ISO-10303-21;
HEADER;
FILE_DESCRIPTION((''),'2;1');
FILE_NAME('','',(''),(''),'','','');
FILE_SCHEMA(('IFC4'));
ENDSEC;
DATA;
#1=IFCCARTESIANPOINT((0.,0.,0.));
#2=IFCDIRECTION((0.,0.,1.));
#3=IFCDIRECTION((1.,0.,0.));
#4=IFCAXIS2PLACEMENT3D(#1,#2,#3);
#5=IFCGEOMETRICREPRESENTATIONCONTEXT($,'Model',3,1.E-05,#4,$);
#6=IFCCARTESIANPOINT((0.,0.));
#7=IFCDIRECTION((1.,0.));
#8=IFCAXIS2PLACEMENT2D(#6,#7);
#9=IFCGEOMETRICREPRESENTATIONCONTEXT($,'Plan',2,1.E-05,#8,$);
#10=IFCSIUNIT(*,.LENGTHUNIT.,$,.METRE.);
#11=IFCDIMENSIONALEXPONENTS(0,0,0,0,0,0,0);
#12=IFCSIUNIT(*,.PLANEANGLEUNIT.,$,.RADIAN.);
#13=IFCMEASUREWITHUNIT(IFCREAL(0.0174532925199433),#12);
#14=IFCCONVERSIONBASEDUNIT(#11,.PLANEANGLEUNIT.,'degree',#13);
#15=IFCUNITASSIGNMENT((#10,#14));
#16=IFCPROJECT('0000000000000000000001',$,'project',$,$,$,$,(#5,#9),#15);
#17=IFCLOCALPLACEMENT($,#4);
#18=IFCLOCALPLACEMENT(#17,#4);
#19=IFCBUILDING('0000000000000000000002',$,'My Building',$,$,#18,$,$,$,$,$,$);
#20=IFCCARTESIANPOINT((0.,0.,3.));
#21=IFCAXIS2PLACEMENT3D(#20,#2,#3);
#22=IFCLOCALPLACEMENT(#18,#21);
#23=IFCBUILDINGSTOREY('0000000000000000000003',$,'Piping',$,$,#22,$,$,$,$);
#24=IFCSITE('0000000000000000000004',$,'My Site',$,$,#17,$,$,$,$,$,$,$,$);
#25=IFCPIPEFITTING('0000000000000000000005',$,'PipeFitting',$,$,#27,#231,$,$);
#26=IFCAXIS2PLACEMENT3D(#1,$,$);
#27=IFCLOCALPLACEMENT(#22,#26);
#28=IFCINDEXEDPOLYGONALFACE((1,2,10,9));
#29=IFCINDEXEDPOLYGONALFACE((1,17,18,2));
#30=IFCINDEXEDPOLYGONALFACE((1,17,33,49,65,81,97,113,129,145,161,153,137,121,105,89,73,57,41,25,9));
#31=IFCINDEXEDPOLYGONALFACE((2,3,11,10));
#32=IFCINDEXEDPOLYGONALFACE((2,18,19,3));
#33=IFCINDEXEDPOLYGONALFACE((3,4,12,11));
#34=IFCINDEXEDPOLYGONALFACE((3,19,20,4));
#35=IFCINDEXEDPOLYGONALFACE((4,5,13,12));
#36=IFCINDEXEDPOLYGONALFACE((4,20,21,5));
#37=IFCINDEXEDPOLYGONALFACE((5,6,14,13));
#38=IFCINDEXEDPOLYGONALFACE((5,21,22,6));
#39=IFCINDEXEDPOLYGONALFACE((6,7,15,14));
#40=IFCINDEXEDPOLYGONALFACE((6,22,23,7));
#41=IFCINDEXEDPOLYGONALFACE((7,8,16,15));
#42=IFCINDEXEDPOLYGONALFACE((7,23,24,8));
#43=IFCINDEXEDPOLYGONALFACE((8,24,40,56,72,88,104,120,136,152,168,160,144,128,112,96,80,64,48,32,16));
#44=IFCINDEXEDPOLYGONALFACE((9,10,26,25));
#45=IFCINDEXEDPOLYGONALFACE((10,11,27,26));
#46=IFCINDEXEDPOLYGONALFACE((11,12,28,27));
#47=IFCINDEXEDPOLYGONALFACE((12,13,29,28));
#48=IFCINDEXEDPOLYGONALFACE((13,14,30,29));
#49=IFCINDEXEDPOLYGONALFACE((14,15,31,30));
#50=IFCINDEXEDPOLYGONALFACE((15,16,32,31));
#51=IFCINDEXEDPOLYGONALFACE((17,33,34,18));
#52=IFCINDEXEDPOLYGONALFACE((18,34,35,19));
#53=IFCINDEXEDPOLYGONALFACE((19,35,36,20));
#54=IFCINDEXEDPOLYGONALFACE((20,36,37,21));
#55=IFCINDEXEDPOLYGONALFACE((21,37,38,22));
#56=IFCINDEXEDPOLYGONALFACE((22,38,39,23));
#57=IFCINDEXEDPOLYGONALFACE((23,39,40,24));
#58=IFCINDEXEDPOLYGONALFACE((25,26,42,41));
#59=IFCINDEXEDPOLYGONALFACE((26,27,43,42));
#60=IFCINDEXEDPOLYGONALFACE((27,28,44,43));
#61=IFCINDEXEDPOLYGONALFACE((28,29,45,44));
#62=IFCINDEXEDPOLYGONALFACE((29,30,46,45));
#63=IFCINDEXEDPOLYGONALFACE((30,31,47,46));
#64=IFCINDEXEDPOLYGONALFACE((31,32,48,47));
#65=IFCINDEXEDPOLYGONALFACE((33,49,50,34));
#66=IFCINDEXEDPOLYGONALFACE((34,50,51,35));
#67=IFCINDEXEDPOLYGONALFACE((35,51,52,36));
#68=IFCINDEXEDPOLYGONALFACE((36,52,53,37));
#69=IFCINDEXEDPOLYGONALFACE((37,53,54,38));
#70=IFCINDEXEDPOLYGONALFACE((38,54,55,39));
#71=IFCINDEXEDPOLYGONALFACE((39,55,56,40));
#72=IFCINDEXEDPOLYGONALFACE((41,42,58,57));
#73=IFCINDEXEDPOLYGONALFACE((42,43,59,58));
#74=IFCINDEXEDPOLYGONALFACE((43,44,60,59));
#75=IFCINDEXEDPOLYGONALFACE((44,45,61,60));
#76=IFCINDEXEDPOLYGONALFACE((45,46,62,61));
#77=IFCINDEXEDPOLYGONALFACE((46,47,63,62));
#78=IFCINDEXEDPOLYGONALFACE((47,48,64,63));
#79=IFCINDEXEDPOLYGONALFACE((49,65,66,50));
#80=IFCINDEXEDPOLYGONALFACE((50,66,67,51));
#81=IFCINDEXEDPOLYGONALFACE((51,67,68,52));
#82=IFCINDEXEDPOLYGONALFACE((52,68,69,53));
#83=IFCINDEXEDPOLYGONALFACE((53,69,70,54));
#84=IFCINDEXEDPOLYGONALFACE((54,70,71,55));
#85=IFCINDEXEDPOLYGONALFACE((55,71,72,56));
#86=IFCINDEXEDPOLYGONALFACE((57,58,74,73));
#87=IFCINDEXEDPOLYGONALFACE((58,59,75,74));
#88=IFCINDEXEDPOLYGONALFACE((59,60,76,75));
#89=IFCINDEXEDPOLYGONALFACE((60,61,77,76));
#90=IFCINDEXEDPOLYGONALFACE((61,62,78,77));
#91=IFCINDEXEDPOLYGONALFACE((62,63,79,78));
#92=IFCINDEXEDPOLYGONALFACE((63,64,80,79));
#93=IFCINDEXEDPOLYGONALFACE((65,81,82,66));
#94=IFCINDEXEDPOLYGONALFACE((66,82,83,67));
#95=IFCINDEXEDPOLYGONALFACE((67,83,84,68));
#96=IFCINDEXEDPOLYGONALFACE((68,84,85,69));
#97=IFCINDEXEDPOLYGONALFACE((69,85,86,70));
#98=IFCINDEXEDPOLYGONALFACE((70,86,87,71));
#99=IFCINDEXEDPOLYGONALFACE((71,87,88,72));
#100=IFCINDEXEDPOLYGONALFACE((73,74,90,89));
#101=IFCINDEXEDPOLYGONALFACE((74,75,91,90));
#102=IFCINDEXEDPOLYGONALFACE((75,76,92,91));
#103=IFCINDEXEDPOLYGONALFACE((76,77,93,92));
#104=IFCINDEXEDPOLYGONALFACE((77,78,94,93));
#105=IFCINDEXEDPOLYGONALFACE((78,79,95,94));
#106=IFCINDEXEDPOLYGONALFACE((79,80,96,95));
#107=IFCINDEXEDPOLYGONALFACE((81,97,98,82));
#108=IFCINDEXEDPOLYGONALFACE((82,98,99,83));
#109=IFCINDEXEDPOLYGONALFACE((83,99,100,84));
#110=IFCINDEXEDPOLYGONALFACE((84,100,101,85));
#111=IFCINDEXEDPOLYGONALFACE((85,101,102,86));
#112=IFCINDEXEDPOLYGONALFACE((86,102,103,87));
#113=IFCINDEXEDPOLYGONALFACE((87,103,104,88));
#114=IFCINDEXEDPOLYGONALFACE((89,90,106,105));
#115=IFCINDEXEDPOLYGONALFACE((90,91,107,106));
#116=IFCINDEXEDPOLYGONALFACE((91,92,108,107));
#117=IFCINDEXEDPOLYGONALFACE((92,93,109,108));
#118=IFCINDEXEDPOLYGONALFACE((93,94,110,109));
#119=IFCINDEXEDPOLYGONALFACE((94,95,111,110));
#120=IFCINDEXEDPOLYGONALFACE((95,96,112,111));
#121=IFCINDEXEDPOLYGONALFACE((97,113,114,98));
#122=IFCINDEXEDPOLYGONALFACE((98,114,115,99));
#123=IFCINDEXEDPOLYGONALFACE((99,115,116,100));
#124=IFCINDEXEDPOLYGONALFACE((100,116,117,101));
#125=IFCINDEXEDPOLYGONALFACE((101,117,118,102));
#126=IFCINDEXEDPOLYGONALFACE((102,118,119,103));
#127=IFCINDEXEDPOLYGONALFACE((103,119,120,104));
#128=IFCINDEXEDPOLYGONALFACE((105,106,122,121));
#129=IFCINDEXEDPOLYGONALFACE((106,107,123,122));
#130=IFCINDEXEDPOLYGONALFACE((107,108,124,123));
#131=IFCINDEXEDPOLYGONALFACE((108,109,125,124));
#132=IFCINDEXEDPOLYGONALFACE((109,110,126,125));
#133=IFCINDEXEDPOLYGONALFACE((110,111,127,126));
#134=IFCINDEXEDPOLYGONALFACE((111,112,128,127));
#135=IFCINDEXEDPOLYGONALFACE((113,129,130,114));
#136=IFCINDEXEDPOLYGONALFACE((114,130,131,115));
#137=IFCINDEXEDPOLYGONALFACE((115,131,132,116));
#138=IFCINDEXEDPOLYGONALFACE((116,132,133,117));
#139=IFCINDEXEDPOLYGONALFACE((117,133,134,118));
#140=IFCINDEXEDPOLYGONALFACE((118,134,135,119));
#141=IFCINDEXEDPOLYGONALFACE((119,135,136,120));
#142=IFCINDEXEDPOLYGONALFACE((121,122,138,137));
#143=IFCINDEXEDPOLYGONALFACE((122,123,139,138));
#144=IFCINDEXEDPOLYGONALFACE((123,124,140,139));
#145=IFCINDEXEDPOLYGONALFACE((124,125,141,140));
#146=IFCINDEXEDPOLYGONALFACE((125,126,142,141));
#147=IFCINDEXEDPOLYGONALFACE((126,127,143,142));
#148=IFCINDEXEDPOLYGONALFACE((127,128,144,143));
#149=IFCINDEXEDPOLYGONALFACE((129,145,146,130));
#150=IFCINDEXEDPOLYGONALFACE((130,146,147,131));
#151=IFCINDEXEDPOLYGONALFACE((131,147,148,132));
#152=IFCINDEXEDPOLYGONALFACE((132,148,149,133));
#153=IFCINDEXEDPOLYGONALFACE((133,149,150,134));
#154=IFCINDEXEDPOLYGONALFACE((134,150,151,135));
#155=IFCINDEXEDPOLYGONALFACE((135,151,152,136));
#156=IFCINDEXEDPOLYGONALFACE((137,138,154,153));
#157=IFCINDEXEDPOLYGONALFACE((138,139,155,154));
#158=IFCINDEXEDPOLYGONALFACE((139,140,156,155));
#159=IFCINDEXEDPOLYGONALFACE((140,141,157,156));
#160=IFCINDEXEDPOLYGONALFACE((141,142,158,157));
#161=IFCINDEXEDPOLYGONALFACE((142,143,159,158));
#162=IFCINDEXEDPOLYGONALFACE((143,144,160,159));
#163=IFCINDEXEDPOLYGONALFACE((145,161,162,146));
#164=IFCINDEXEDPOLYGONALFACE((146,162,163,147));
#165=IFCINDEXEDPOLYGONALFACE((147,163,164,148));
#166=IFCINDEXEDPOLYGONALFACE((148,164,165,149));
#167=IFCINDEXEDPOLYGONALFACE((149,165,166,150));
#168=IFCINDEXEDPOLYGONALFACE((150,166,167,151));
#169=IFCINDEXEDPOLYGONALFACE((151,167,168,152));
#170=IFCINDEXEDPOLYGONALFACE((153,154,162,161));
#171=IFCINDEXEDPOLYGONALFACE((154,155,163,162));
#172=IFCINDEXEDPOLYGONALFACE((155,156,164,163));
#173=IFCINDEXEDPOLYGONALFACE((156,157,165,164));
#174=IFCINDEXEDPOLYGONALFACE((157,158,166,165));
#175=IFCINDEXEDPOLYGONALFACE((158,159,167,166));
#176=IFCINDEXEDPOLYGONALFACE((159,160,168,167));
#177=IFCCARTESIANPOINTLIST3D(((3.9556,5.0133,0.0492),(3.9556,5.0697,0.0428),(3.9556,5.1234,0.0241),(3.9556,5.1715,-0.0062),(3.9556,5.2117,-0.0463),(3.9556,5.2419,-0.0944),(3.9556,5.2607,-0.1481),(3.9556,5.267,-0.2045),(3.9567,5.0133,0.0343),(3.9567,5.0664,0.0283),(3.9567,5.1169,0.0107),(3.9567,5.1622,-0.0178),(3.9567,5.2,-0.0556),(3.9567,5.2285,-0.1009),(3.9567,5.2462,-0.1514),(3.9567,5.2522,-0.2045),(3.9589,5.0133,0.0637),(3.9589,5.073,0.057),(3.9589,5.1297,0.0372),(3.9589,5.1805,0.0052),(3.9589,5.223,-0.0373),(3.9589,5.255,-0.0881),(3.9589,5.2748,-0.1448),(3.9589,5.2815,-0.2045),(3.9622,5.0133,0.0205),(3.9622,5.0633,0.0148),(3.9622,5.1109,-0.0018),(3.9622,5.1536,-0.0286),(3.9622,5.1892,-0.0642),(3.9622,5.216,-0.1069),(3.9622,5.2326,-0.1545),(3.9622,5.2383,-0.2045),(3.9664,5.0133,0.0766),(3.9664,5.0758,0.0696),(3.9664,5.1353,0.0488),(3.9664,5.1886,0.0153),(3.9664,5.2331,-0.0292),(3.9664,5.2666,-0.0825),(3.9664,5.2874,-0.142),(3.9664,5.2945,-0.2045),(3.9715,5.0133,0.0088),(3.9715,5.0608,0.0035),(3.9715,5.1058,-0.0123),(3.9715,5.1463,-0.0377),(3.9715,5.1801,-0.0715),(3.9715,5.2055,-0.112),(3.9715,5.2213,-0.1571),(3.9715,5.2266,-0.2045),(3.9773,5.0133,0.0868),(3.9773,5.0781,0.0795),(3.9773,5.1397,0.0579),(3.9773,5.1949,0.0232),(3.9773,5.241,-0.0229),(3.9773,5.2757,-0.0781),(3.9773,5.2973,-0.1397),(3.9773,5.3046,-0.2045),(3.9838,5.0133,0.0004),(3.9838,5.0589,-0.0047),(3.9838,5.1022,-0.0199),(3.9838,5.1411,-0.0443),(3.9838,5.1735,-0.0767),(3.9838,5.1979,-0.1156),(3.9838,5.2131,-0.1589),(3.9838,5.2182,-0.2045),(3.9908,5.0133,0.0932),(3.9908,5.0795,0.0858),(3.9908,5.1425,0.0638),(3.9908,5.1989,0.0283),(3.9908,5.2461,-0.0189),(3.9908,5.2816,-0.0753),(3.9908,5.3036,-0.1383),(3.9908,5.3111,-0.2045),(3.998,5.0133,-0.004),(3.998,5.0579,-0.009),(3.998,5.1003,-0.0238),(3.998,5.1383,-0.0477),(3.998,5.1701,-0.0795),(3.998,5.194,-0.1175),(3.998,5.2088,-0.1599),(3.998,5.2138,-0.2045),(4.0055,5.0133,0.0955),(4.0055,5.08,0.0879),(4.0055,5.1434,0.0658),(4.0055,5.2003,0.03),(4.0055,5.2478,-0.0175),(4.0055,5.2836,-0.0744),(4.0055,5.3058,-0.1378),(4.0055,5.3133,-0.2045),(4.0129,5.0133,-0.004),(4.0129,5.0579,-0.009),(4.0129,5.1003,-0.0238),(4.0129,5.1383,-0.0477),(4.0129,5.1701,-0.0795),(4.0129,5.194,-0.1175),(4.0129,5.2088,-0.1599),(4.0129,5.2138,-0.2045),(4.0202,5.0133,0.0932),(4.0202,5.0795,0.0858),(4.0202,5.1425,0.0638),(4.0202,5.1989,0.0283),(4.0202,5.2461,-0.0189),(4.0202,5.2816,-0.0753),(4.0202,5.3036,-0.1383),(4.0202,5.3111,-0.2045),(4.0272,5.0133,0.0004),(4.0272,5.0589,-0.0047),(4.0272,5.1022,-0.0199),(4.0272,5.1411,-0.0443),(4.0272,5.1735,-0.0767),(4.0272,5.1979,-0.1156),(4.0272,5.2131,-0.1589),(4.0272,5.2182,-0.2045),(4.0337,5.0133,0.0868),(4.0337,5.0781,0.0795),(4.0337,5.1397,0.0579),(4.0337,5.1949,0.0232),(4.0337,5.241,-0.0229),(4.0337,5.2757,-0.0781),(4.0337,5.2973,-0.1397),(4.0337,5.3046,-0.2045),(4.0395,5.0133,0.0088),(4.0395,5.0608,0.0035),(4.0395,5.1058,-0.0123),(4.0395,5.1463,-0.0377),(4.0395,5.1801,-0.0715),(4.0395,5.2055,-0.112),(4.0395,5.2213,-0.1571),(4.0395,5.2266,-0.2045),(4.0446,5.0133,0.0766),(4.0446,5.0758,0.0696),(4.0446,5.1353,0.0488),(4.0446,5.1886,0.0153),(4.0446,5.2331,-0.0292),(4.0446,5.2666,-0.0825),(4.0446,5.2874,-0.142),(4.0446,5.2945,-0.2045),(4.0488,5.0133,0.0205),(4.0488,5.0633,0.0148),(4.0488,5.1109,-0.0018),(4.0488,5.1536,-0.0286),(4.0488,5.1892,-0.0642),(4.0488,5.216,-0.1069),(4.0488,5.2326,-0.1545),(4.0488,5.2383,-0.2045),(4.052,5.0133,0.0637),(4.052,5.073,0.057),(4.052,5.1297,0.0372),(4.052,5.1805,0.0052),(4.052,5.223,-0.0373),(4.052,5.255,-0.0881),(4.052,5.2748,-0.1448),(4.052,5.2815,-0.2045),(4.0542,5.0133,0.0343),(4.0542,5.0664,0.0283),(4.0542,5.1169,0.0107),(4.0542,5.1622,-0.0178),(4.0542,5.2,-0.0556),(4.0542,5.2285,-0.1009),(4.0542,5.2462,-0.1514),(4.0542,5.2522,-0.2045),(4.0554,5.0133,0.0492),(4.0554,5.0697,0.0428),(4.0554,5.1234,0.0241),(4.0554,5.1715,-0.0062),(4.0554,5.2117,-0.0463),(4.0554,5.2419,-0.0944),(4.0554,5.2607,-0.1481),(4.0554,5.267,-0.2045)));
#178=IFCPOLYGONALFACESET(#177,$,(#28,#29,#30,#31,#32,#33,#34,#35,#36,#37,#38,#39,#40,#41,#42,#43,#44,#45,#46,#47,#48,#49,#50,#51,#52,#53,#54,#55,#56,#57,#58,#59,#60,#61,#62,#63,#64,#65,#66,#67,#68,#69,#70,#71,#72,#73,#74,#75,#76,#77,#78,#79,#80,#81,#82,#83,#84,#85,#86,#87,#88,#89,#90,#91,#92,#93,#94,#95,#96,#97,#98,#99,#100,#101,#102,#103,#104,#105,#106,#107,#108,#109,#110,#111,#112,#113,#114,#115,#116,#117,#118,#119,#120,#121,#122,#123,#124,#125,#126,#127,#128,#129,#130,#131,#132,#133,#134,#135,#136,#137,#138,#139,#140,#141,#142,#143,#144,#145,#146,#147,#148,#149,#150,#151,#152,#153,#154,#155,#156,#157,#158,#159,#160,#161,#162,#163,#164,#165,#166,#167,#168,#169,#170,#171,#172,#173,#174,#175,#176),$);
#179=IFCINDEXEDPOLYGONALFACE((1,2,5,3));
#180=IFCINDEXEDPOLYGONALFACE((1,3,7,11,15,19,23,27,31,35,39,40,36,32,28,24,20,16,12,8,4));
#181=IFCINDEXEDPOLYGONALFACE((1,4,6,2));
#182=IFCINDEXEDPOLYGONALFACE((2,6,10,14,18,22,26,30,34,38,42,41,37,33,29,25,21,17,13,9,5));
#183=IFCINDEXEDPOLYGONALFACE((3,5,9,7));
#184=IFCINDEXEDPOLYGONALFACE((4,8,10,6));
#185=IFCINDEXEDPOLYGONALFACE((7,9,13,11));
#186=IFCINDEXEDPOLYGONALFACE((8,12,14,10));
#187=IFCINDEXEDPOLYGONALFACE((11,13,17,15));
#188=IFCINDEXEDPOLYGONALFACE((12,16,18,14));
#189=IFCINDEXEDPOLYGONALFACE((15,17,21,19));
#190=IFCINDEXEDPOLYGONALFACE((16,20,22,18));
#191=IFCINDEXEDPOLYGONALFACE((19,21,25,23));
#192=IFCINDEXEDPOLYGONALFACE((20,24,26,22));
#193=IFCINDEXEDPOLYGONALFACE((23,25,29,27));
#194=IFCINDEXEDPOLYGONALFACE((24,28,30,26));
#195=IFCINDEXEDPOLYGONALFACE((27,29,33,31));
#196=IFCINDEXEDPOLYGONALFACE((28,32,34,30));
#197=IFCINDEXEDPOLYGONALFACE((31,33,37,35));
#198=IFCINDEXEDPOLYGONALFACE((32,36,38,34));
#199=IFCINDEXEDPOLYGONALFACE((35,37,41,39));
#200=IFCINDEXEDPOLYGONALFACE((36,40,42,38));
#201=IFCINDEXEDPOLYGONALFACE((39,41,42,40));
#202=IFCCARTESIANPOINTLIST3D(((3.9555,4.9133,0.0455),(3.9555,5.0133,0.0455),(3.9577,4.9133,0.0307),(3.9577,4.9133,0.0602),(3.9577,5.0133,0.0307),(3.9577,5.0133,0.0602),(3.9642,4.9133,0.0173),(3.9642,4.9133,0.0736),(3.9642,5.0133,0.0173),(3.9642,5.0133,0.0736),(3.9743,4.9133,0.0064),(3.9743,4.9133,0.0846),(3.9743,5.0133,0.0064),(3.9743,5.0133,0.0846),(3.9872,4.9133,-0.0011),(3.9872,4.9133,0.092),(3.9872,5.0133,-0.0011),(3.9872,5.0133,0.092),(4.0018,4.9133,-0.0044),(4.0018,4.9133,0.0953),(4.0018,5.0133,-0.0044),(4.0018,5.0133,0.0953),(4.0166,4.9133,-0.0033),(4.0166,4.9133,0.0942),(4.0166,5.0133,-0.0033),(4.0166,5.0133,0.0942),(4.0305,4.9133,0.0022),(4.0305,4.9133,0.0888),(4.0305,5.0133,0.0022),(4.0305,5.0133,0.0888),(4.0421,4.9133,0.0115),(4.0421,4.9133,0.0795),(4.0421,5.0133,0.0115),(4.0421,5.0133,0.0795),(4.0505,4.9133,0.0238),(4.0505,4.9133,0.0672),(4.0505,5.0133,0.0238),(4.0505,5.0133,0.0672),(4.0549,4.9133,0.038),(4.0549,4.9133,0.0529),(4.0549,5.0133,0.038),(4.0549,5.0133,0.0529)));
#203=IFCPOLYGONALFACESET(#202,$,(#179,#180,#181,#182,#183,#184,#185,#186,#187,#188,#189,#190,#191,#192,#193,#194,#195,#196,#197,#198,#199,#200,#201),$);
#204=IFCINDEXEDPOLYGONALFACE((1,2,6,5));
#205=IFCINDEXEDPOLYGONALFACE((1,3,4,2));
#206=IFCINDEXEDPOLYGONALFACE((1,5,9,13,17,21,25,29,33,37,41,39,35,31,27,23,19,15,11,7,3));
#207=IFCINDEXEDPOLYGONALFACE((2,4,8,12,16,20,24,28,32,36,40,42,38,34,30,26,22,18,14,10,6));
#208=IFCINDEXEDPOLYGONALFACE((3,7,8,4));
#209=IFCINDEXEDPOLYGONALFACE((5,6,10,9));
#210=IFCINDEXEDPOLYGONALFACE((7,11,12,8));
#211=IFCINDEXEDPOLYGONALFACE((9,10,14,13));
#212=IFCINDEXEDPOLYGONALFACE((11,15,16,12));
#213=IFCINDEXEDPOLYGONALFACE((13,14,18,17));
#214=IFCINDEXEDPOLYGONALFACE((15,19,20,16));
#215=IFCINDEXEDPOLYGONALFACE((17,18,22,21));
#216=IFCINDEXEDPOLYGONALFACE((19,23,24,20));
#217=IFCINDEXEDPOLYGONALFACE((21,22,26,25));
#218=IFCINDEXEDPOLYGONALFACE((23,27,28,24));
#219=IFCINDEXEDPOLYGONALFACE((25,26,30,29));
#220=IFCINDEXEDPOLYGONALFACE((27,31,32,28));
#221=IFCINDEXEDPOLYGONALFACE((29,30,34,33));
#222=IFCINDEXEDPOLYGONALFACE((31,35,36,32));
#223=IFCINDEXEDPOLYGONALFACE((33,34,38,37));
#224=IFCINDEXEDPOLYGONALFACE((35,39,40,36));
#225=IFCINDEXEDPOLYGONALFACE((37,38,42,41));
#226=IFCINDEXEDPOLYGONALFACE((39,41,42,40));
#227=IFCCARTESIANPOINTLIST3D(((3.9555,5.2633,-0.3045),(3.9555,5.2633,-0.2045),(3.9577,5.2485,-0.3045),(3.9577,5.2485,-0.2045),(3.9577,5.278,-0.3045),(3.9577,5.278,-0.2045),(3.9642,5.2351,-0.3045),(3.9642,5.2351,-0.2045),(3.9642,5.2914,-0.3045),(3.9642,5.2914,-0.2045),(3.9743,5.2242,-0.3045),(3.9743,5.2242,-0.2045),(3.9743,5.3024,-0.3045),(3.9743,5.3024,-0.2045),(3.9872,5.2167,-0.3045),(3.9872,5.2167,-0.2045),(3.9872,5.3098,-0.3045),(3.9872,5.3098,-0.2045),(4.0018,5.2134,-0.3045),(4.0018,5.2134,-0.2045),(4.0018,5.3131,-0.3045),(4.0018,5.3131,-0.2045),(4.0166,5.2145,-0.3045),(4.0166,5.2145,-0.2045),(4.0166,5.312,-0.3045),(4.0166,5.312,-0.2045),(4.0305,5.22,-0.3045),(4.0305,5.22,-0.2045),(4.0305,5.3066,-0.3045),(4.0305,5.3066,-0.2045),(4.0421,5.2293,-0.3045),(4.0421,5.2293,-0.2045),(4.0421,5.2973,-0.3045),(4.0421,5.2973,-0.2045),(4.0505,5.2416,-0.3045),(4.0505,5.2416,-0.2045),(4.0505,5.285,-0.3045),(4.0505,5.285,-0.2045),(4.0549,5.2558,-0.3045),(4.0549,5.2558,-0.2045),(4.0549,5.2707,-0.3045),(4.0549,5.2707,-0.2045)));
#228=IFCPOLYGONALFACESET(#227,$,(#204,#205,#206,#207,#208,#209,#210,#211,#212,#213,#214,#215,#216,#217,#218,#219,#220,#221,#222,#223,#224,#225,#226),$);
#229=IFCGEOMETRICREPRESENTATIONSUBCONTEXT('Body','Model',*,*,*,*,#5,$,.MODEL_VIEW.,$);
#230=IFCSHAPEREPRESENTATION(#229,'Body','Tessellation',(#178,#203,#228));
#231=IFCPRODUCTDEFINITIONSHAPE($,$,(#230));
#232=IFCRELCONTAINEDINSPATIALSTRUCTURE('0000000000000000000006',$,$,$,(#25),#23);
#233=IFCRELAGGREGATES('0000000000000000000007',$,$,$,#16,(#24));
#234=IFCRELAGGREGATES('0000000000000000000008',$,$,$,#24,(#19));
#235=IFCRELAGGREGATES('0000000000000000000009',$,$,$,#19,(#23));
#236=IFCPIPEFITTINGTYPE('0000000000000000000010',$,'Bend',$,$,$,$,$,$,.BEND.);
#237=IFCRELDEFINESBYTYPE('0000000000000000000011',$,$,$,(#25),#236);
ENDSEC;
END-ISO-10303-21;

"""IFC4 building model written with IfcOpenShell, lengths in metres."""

from ifc_helpers import new_model, entity, si_unit, converted_unit, frame, origin_with_axes, origin_2d_with_axis, place, context, subcontext, project, spatial, circle, extrude, source, transform, mapped, type_object, type_shapes, element, save


model = new_model("IFC4")

# Units and contexts
model_context = context("Model", 3, precision=1e-05, world=origin_with_axes())
plan_context = context("Plan", 2, precision=1e-05, world=origin_2d_with_axis())
body_context = subcontext(model_context, "Body", "Model", "MODEL_VIEW")
ifc_project = project(units=[si_unit("LENGTHUNIT", "METRE"), converted_unit("PLANEANGLEUNIT", "degree", entity("IfcReal", 0.0174532925199433), si_unit("PLANEANGLEUNIT", "RADIAN"), dimensions=[0, 0, 0, 0, 0, 0, 0])], contexts=[model_context, plan_context])

# Site, building, storey
site_placement = place(None, origin_with_axes())
site = spatial("IfcSite", under=ifc_project, at=site_placement, Name="My Site")
building_placement = place(site_placement, origin_with_axes())
building = spatial("IfcBuilding", under=site, at=building_placement, Name="My Building")
storey_placement = place(building_placement, frame((0.0, 0.0, 3.0), z_axis=(0.0, 0.0, 1.0), x_axis=(1.0, 0.0, 0.0)))
storey = spatial("IfcBuildingStorey", under=building, at=storey_placement, Name="Piping")

# Pipe fitting
pipe_fitting_type_1 = type_object("IfcPipeFittingType", Name="Bend", PredefinedType="BEND")
shared_shape_1 = source(origin_with_axes(), body_context, "Body", "SolidModel", [
    entity("IfcSweptDiskSolid", entity("IfcIndexedPolyCurve", entity("IfcCartesianPointList3D", [[0.0, 0.0, 0.1], [0.0, -0.0732, 0.2768], [0.0, -0.25, 0.35]]), [entity("IfcArcIndex", [1, 2, 3])]), 0.05),
    extrude(circle(Radius=0.05), origin_with_axes(), (0.0, 0.0, 1.0), 0.1),
    extrude(circle(Radius=0.05), frame((0.0, -0.25, 0.35), z_axis=(0.0, -1.0, 0.0), x_axis=(1.0, 0.0, 0.0)), (0.0, 0.0, 1.0), 0.1),
])
type_shapes(pipe_fitting_type_1, [shared_shape_1])
for number, where, z_axis, x_axis, name in (
    (1, (4.0055, 4.9133, 0.0455), (0.0, 1.0, 0.0), (-1.0, 0.0, 0.0), "PipeFitting"),
):
    element("IfcPipeFitting", number, at=place(storey_placement, frame(where, z_axis=z_axis, x_axis=x_axis)), inside=storey, type_object=pipe_fitting_type_1, Name=name, context=body_context, shape_type="MappedRepresentation", body=[
        mapped(shared_shape_1, transform((0.0, 0.0, 0.0), x_axis=(1.0, 0.0, 0.0), y_axis=(0.0, 1.0, 0.0), z_axis=(0.0, 0.0, 1.0), scale=1.0)),
    ])

save(model, "model.ifc")
